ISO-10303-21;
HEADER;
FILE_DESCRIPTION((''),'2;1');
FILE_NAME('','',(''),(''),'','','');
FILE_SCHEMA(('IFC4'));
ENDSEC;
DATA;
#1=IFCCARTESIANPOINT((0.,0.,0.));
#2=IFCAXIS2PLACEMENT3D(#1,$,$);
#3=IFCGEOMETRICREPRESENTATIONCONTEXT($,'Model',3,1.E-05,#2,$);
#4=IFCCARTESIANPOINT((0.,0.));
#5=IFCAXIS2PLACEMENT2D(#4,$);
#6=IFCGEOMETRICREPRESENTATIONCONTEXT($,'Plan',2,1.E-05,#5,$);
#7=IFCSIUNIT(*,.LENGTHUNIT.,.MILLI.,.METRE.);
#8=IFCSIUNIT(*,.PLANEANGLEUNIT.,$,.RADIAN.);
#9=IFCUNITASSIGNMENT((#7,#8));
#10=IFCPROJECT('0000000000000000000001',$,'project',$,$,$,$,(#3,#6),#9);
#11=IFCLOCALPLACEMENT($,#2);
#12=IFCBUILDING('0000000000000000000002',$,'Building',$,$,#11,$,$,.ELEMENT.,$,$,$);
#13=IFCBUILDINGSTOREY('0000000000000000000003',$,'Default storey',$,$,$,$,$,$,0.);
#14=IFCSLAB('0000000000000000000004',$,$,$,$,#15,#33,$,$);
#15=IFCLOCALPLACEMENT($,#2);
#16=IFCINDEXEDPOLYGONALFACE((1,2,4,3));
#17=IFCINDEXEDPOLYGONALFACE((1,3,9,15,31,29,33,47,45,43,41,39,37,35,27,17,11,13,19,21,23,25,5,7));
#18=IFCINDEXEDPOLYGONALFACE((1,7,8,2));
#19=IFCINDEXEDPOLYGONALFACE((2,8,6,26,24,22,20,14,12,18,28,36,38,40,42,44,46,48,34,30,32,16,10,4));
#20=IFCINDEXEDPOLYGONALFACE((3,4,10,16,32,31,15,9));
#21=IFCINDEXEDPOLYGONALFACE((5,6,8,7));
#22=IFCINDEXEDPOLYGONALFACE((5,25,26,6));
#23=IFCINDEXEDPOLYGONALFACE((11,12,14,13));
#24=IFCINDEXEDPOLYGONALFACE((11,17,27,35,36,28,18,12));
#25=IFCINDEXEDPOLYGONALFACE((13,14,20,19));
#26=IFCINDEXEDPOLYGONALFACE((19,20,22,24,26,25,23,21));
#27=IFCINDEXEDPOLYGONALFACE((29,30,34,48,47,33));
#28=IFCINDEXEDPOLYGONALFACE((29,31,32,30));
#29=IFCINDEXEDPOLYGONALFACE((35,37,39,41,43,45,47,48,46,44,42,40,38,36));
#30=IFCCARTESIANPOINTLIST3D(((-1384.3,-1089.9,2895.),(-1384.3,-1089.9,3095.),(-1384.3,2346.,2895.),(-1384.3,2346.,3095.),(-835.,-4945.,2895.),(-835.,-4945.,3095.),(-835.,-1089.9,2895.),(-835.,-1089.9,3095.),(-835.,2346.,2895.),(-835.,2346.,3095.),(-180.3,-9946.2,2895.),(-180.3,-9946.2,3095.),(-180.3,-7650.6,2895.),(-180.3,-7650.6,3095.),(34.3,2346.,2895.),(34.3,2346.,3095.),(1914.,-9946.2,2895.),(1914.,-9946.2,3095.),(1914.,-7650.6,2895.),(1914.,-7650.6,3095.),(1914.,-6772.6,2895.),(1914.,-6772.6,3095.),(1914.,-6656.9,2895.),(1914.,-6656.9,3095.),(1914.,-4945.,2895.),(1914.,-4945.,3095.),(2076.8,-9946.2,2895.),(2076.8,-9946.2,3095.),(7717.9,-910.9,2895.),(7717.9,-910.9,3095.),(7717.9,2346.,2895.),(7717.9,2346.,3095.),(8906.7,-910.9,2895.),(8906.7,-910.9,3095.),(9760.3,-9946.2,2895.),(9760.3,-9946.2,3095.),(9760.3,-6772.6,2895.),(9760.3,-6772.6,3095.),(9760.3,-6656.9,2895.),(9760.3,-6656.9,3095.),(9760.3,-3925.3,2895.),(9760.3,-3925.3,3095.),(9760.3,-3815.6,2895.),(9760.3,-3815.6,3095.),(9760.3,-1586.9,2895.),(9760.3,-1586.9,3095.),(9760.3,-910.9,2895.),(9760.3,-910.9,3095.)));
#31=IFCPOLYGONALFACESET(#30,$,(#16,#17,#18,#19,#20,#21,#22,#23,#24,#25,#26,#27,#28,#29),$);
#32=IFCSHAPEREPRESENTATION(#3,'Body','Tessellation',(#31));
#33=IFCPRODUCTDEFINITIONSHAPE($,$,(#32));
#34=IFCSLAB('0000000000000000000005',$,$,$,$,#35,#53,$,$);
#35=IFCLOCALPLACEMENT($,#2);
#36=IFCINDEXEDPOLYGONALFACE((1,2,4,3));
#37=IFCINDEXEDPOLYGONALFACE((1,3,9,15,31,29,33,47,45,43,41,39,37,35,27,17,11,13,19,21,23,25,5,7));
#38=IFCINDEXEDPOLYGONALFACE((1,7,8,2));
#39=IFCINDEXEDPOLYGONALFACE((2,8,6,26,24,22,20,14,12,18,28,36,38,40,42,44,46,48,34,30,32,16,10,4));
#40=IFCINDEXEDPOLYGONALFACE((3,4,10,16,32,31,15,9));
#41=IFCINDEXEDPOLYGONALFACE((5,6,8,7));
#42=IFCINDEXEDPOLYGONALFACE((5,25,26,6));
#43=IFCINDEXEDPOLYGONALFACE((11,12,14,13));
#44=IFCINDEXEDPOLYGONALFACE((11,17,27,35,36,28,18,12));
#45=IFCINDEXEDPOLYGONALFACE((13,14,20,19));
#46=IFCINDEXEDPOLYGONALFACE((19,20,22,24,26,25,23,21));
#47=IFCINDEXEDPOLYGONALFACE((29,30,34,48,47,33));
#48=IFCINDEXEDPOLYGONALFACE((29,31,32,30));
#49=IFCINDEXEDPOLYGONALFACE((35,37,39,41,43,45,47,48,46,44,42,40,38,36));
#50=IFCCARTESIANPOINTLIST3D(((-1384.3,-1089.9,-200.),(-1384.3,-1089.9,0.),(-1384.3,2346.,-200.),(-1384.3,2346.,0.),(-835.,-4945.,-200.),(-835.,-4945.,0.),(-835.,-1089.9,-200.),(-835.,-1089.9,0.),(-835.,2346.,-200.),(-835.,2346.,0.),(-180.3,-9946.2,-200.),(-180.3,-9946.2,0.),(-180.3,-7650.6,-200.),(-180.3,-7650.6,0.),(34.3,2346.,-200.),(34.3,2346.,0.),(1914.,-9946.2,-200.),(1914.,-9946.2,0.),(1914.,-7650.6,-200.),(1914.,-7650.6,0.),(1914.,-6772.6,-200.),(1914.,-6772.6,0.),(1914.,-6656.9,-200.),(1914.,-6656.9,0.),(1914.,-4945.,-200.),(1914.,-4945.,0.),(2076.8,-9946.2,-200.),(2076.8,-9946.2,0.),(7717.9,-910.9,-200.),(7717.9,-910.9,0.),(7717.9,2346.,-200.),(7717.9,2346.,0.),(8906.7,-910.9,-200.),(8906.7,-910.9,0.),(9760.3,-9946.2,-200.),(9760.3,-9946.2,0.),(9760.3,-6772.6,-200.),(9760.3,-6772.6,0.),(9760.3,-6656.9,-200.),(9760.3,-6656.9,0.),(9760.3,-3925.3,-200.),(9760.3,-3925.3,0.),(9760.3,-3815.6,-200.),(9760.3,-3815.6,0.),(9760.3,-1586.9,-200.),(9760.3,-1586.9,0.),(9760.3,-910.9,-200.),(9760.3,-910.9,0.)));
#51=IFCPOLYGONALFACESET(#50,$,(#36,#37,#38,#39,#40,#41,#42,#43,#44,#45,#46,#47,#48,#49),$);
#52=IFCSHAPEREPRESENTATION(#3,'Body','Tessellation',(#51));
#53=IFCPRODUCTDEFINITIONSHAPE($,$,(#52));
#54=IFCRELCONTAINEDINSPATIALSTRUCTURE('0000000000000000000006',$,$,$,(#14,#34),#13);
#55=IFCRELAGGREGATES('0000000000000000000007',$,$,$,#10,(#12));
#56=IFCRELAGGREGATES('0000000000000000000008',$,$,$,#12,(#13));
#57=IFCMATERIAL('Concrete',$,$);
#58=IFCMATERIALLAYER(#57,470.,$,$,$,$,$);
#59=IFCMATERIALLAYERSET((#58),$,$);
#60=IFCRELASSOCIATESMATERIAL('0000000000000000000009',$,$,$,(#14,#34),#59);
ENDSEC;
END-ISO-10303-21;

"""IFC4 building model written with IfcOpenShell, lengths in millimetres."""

from ifc_helpers import new_model, si_unit, frame, origin, origin_2d, place, context, project, spatial, polyline, outline, extrude, material, layer, layer_set, layer_usage, element, save


model = new_model("IFC4")

# Units and contexts
model_context = context("Model", 3, precision=1e-05, world=origin())
plan_context = context("Plan", 2, precision=1e-05, world=origin_2d())
ifc_project = project(units=[si_unit("LENGTHUNIT", "METRE", prefix="MILLI"), si_unit("PLANEANGLEUNIT", "RADIAN")], contexts=[model_context, plan_context])

# Building, storey
placement = place(None, origin())
building = spatial("IfcBuilding", under=ifc_project, at=placement, Name="Building", CompositionType="ELEMENT")
storey = spatial("IfcBuildingStorey", under=building, Name="Default storey", Elevation=0.0)

# Slabs
ifc_material_1 = material(Name="Concrete")
ifc_layer_1 = layer(ifc_material_1, 470.0)
ifc_layer_set_1 = layer_set([ifc_layer_1])
ifc_layer_usage_1 = layer_usage(ifc_layer_set_1, "AXIS3", "POSITIVE", 0.0)
element("IfcSlab", 1, at=placement, inside=storey, material=ifc_layer_usage_1, context=model_context, shape_type="SweptSolid", body=[
    extrude(outline(polyline([(8906.7, -910.9, 0.0), (7717.9, -910.9, 0.0), (7717.9, 2346.0, 0.0), (34.3, 2346.0, 0.0), (-835.0, 2346.0, 0.0), (-1384.3, 2346.0, 0.0), (-1384.3, -1089.9, 0.0), (-835.0, -1089.9, 0.0), (-835.0, -4945.0, 0.0), (1914.0, -4945.0, 0.0), (1914.0, -6656.9, 0.0), (1914.0, -6772.6, 0.0), (1914.0, -7650.6, 0.0), (-180.3, -7650.6, 0.0), (-180.3, -9946.2, 0.0), (1914.0, -9946.2, 0.0), (2076.8, -9946.2, 0.0), (9760.3, -9946.2, 0.0), (9760.3, -6772.6, 0.0), (9760.3, -6656.9, 0.0), (9760.3, -3925.3, 0.0), (9760.3, -3815.6, 0.0), (9760.3, -1586.9, 0.0), (9760.3, -910.9, 0.0), (8906.7, -910.9, 0.0)])), frame((0.0, 0.0, 2895.0), z_axis=(0.0, 0.0, 1000.0), x_axis=(1000.0, 0.0, 0.0)), (0.0, 0.0, 1.0), 200.0),
])
element("IfcSlab", 2, at=placement, inside=storey, material=ifc_layer_usage_1, context=model_context, shape_type="SweptSolid", body=[
    extrude(outline(polyline([(8906.7, -910.9, 0.0), (7717.9, -910.9, 0.0), (7717.9, 2346.0, 0.0), (34.3, 2346.0, 0.0), (-835.0, 2346.0, 0.0), (-1384.3, 2346.0, 0.0), (-1384.3, -1089.9, 0.0), (-835.0, -1089.9, 0.0), (-835.0, -4945.0, 0.0), (1914.0, -4945.0, 0.0), (1914.0, -6656.9, 0.0), (1914.0, -6772.6, 0.0), (1914.0, -7650.6, 0.0), (-180.3, -7650.6, 0.0), (-180.3, -9946.2, 0.0), (1914.0, -9946.2, 0.0), (2076.8, -9946.2, 0.0), (9760.3, -9946.2, 0.0), (9760.3, -6772.6, 0.0), (9760.3, -6656.9, 0.0), (9760.3, -3925.3, 0.0), (9760.3, -3815.6, 0.0), (9760.3, -1586.9, 0.0), (9760.3, -910.9, 0.0), (8906.7, -910.9, 0.0)])), frame((0.0, 0.0, 0.0), z_axis=(0.0, 0.0, 1000.0), x_axis=(1000.0, 0.0, 0.0)), (0.0, 0.0, -1.0), 200.0),
])

save(model, "model.ifc")
